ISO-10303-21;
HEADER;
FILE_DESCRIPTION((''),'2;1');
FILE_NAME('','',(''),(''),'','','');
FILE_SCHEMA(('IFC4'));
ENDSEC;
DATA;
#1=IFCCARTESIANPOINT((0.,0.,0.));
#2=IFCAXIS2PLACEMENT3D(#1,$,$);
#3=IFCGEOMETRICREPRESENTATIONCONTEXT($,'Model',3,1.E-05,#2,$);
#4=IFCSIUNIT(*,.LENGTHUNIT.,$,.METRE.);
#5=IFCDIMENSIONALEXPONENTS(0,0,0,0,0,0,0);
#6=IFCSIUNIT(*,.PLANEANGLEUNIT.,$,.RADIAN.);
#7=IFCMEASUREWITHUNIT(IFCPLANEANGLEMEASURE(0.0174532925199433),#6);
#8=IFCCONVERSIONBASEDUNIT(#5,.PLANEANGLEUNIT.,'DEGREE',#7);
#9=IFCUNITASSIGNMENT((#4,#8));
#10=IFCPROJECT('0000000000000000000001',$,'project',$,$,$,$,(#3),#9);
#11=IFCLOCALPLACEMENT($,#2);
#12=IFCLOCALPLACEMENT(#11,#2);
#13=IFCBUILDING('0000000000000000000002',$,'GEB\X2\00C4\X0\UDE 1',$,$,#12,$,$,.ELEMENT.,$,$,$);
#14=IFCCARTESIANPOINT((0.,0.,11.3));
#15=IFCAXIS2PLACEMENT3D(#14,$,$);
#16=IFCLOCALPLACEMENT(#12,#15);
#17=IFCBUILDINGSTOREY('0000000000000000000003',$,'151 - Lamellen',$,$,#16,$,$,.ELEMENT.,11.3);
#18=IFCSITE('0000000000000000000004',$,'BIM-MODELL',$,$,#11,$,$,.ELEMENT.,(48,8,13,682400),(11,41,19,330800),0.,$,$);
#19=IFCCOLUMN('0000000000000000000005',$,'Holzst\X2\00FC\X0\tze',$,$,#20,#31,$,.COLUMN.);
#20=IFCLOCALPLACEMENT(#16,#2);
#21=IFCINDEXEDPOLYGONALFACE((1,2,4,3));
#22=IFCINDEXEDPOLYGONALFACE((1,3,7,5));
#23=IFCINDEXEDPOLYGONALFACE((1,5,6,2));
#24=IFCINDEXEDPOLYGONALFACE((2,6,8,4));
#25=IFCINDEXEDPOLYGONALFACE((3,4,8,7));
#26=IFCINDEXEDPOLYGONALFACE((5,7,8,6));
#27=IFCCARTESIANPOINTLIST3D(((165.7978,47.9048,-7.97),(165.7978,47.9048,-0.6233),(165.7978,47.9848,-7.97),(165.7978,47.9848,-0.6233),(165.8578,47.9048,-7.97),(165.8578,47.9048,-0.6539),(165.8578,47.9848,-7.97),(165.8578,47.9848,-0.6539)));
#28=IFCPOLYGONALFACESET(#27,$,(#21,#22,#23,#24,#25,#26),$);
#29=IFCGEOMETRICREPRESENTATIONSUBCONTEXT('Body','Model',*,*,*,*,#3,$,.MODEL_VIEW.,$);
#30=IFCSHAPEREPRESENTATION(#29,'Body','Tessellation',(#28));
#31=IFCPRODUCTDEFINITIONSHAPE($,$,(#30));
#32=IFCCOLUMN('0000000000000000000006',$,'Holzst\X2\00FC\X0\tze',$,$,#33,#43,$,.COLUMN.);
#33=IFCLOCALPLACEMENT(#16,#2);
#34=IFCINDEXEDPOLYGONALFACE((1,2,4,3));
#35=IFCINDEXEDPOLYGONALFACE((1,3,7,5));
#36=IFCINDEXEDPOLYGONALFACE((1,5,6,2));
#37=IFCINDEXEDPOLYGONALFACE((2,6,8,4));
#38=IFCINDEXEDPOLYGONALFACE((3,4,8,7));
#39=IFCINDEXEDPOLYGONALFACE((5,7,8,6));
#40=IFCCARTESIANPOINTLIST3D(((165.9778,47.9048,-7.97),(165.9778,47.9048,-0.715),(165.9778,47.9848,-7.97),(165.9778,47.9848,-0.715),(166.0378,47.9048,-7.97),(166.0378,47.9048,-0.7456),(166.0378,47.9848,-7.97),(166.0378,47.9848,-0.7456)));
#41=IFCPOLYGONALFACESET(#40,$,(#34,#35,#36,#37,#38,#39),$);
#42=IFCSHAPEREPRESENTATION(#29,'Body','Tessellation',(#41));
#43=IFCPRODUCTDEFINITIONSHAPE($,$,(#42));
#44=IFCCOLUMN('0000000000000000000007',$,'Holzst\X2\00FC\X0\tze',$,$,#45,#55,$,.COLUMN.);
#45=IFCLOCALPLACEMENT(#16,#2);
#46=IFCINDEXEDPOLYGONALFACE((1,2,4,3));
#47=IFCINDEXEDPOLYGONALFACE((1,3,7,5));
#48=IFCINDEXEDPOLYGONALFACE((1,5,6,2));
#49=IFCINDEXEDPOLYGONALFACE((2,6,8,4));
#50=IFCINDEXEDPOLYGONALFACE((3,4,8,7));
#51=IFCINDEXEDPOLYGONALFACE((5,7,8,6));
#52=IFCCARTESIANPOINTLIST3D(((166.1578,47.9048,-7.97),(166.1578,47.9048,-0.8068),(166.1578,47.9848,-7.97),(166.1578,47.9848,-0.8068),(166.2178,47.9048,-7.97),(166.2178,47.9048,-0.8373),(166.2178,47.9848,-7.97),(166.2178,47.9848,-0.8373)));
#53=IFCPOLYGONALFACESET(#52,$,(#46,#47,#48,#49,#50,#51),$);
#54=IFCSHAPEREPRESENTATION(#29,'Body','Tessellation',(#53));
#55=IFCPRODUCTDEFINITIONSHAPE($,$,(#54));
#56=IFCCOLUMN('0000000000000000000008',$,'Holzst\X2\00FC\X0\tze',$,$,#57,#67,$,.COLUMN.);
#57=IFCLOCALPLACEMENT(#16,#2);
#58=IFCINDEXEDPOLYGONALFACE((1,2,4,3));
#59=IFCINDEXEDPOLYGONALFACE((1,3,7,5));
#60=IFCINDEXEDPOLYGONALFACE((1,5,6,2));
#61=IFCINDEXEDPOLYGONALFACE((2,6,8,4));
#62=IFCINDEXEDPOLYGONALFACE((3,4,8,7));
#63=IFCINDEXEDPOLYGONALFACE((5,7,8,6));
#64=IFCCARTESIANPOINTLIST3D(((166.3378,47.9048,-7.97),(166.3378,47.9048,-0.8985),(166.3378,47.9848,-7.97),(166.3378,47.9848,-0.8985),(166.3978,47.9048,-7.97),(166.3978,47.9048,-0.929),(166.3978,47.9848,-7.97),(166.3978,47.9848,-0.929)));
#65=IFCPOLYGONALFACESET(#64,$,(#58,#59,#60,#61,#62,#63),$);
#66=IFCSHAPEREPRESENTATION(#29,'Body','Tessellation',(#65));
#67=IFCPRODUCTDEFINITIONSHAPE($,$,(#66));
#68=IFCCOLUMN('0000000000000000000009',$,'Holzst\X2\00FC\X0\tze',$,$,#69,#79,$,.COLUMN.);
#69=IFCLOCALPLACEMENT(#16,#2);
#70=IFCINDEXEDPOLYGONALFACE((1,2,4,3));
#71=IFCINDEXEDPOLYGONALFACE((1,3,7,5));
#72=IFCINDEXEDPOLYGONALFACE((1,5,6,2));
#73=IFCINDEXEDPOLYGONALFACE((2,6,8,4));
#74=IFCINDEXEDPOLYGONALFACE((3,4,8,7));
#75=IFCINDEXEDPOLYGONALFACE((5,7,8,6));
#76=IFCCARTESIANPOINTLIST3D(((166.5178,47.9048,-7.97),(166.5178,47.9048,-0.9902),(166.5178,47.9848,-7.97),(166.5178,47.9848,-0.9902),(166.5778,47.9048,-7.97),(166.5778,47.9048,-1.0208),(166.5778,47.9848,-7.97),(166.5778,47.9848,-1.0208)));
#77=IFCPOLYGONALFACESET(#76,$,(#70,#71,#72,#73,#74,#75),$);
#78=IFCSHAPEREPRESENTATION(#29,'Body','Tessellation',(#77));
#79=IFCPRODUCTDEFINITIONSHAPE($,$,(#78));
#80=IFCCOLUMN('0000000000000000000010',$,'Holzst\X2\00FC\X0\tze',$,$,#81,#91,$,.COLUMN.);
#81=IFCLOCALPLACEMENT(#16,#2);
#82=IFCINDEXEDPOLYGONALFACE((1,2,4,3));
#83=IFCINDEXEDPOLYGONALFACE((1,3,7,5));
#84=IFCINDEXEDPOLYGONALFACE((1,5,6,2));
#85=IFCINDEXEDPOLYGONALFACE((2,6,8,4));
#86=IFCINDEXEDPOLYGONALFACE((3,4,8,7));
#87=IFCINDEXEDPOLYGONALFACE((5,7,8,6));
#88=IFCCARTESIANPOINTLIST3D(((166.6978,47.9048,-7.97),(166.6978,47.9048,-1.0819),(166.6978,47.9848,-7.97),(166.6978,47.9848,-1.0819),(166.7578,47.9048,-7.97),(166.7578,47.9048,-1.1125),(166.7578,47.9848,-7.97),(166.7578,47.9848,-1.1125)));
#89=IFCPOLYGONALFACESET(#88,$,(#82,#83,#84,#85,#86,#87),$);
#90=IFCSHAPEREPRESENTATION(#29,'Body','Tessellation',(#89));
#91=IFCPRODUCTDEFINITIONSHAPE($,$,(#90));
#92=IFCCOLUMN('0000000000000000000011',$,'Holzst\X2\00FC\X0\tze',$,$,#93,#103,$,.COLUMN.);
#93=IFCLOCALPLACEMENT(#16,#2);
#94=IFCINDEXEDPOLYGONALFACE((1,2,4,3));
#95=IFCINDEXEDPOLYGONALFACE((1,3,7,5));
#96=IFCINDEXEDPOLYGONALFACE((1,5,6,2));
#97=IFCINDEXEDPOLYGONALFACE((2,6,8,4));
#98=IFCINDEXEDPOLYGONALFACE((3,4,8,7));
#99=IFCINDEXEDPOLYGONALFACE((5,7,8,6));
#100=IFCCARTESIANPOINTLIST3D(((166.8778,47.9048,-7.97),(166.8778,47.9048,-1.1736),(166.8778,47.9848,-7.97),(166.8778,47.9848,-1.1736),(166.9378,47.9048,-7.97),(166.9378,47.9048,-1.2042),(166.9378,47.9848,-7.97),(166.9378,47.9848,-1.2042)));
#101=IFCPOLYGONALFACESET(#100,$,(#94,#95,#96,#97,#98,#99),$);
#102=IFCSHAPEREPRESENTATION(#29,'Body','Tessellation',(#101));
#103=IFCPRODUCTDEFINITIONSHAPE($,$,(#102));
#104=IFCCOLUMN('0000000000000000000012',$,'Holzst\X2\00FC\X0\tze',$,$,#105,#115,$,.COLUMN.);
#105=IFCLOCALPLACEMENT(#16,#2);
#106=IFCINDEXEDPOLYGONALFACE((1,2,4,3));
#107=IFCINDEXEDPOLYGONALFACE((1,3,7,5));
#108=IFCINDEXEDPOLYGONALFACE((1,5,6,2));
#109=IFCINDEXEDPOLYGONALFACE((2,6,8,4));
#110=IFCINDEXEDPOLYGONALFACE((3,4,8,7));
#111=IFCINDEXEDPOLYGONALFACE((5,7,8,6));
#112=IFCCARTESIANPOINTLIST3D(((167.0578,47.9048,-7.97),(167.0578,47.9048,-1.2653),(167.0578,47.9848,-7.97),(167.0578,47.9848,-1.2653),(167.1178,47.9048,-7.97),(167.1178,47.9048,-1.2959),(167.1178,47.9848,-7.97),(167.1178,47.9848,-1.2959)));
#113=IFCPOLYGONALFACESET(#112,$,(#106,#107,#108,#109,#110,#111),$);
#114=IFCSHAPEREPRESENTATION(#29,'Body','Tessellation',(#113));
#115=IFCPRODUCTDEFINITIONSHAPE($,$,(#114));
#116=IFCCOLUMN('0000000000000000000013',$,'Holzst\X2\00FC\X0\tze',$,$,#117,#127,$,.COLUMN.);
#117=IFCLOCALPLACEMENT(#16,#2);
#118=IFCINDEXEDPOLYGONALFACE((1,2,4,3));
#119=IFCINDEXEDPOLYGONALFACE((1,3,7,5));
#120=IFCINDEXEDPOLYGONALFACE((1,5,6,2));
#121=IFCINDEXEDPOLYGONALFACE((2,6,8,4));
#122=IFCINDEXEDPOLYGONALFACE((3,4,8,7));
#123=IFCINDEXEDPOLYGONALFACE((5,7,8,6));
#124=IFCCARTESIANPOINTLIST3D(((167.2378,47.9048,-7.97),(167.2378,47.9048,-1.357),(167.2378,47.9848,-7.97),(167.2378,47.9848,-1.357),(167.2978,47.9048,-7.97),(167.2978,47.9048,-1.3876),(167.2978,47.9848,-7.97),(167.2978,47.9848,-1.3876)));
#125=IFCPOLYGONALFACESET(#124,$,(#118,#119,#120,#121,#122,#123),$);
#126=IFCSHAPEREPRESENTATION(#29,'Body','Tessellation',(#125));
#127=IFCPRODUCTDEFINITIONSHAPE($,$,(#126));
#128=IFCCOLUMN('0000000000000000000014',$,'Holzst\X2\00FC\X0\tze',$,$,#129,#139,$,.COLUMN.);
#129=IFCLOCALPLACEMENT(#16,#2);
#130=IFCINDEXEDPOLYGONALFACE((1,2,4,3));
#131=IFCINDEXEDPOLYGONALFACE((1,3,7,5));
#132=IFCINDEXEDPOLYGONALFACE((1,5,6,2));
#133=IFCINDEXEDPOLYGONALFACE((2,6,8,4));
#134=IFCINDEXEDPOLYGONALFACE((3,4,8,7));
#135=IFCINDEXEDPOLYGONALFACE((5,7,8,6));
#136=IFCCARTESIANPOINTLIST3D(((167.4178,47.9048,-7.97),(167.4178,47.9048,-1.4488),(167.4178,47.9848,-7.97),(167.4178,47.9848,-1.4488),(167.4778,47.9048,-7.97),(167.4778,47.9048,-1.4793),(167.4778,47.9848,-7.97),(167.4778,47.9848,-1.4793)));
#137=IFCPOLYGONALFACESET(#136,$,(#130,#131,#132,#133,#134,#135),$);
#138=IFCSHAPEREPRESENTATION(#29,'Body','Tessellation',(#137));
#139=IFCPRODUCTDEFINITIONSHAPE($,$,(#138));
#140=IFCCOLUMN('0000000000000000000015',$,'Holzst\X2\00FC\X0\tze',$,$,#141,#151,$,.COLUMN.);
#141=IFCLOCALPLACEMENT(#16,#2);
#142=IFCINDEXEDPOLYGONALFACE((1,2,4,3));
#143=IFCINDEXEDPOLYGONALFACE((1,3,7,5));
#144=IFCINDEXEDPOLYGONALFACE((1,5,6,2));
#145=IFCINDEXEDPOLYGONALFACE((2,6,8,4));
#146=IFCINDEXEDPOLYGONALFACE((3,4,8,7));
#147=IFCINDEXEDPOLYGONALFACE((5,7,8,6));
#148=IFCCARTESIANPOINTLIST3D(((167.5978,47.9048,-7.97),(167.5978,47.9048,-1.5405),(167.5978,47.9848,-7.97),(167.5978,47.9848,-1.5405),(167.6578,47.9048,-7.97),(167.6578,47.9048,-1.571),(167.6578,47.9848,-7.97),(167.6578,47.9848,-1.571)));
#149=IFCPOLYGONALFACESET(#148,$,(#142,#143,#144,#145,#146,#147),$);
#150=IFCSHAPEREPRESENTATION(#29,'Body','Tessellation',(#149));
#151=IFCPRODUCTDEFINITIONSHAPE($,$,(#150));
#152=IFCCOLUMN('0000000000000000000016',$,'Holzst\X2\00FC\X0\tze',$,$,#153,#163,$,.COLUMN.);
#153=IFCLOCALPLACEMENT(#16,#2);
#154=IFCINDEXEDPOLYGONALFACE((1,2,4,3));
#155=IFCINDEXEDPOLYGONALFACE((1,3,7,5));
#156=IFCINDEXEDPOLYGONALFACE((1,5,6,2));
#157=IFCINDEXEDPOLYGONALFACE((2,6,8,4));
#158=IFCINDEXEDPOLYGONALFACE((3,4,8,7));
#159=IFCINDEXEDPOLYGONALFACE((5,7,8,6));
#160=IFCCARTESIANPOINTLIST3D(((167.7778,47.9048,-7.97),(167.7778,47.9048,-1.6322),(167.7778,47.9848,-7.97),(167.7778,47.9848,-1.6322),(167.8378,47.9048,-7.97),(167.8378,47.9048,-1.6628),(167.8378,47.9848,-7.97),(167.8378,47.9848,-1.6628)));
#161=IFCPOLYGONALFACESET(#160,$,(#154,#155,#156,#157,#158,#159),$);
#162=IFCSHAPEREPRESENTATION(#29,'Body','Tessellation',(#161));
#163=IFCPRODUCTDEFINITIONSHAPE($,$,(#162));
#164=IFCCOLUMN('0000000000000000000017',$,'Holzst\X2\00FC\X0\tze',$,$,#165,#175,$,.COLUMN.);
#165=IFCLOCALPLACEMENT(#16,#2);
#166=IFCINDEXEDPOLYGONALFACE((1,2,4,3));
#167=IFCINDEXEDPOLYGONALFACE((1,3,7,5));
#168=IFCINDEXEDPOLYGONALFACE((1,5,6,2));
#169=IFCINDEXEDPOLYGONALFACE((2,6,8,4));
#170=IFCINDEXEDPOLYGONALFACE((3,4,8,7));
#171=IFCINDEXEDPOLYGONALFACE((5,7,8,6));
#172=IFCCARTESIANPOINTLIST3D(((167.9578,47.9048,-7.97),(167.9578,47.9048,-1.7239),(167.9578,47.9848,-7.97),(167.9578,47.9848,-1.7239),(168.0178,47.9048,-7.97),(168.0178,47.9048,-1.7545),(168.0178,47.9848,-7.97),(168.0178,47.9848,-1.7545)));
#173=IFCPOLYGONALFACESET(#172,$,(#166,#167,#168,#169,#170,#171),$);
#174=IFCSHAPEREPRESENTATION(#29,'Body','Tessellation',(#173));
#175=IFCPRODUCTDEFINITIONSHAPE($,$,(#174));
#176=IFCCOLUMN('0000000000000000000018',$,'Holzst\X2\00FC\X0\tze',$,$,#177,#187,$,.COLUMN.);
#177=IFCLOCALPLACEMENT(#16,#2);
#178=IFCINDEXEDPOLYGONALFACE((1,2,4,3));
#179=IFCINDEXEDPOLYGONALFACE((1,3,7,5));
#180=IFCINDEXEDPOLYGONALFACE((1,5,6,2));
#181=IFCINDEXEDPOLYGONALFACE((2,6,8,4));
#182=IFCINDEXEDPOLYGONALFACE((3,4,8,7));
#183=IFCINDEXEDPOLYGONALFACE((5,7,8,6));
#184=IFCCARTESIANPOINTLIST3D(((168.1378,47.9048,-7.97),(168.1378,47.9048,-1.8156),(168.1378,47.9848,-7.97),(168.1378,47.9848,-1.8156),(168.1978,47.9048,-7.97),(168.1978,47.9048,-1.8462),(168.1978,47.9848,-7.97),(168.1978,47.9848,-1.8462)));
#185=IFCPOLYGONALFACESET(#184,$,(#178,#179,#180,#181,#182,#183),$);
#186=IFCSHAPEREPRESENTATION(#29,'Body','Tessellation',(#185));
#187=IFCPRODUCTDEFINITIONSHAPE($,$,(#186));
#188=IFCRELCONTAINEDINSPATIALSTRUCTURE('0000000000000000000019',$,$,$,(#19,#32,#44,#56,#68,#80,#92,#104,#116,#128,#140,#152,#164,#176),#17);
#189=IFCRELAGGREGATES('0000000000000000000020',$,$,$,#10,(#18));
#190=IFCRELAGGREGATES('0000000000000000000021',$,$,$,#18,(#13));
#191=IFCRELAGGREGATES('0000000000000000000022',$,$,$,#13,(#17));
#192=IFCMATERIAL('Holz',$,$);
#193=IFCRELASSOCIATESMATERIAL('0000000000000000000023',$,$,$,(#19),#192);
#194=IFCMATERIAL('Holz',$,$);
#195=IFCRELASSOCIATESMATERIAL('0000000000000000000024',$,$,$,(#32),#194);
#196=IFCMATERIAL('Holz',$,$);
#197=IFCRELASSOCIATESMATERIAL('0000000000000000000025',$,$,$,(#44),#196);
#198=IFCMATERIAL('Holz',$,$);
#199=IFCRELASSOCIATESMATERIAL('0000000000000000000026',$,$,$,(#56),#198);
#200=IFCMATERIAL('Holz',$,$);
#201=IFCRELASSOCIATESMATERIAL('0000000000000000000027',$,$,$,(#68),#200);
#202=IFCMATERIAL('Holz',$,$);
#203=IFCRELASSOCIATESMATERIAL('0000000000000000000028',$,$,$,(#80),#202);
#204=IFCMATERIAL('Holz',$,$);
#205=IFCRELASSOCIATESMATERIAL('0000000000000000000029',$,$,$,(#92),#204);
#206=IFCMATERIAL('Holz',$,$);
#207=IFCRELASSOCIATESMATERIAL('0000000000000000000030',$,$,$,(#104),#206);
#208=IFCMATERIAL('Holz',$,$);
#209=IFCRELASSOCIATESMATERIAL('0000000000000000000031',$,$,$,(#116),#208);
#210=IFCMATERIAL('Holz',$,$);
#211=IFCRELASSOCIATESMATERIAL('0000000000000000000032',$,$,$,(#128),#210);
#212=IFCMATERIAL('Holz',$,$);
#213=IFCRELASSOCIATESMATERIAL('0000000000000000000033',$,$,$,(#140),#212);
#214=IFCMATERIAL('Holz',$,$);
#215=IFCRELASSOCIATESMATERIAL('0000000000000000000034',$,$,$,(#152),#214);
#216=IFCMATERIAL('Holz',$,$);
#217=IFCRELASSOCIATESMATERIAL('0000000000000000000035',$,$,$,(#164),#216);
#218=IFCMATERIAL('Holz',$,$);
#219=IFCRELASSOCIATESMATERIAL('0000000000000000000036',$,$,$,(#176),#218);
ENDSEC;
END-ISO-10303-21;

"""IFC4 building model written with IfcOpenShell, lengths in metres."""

from ifc_helpers import new_model, entity, si_unit, converted_unit, frame, frame_2d, origin, origin_with_axes, place, context, subcontext, project, spatial, rectangle, extrude, clip, halfspace, material, element, save


model = new_model("IFC4")

# Units and contexts
model_context = context("Model", 3, precision=1e-05, world=origin())
body_context = subcontext(model_context, "Body", "Model", "MODEL_VIEW")
ifc_project = project(units=[si_unit("LENGTHUNIT", "METRE"), converted_unit("PLANEANGLEUNIT", "DEGREE", entity("IfcPlaneAngleMeasure", 0.0174532925199433), si_unit("PLANEANGLEUNIT", "RADIAN"), dimensions=[0, 0, 0, 0, 0, 0, 0])], contexts=[model_context])

# Site, building, storey
site_placement = place(None, origin())
site = spatial("IfcSite", under=ifc_project, at=site_placement, Name="BIM-MODELL", CompositionType="ELEMENT", RefLatitude=(48, 8, 13, 682400), RefLongitude=(11, 41, 19, 330800), RefElevation=0.0)
building_placement = place(site_placement, origin())
building = spatial("IfcBuilding", under=site, at=building_placement, Name="GEBÄUDE 1", CompositionType="ELEMENT")
storey_placement = place(building_placement, frame((0.0, 0.0, 11.3)))
storey = spatial("IfcBuildingStorey", under=building, at=storey_placement, Name="151 - Lamellen", CompositionType="ELEMENT", Elevation=11.3)

# Columns
ifc_material_1 = material(Name="Holz")
column_1_placement = place(storey_placement, frame((165.7978, 47.9048, -7.97)))
element("IfcColumn", 1, at=column_1_placement, inside=storey, material=ifc_material_1, Name="Holzstütze", PredefinedType="COLUMN", context=body_context, shape_type="Clipping", body=[
    clip(extrude(rectangle(XDim=0.06, YDim=0.08, at=frame_2d((0.03, 0.04), x_axis=(1.0, 0.0))), origin_with_axes(), (0.0, 0.0, 1.0), 7.3467), halfspace(frame((0.03, 0.04, 7.3314), z_axis=(-0.45399, 0.0, -0.891007), x_axis=(0.0, 1.0, 0.0)), True)),
])
ifc_material_2 = material(Name="Holz")
column_2_placement = place(storey_placement, frame((165.9778, 47.9048, -7.97)))
element("IfcColumn", 2, at=column_2_placement, inside=storey, material=ifc_material_2, Name="Holzstütze", PredefinedType="COLUMN", context=body_context, shape_type="Clipping", body=[
    clip(extrude(rectangle(XDim=0.06, YDim=0.08, at=frame_2d((0.03, 0.04), x_axis=(1.0, 0.0))), origin_with_axes(), (0.0, 0.0, 1.0), 7.255), halfspace(frame((0.03, 0.04, 7.2397), z_axis=(-0.45399, 0.0, -0.891007), x_axis=(0.0, 1.0, 0.0)), True)),
])
ifc_material_3 = material(Name="Holz")
column_3_placement = place(storey_placement, frame((166.1578, 47.9048, -7.97)))
element("IfcColumn", 3, at=column_3_placement, inside=storey, material=ifc_material_3, Name="Holzstütze", PredefinedType="COLUMN", context=body_context, shape_type="Clipping", body=[
    clip(extrude(rectangle(XDim=0.06, YDim=0.08, at=frame_2d((0.03, 0.04), x_axis=(1.0, 0.0))), origin_with_axes(), (0.0, 0.0, 1.0), 7.1632), halfspace(frame((0.03, 0.04, 7.148), z_axis=(-0.45399, 0.0, -0.891007), x_axis=(0.0, 1.0, 0.0)), True)),
])
ifc_material_4 = material(Name="Holz")
column_4_placement = place(storey_placement, frame((166.3378, 47.9048, -7.97)))
element("IfcColumn", 4, at=column_4_placement, inside=storey, material=ifc_material_4, Name="Holzstütze", PredefinedType="COLUMN", context=body_context, shape_type="Clipping", body=[
    clip(extrude(rectangle(XDim=0.06, YDim=0.08, at=frame_2d((0.03, 0.04), x_axis=(1.0, 0.0))), origin_with_axes(), (0.0, 0.0, 1.0), 7.0715), halfspace(frame((0.03, 0.04, 7.0562), z_axis=(-0.45399, 0.0, -0.891007), x_axis=(0.0, 1.0, 0.0)), True)),
])
ifc_material_5 = material(Name="Holz")
column_5_placement = place(storey_placement, frame((166.5178, 47.9048, -7.97)))
element("IfcColumn", 5, at=column_5_placement, inside=storey, material=ifc_material_5, Name="Holzstütze", PredefinedType="COLUMN", context=body_context, shape_type="Clipping", body=[
    clip(extrude(rectangle(XDim=0.06, YDim=0.08, at=frame_2d((0.03, 0.04), x_axis=(1.0, 0.0))), origin_with_axes(), (0.0, 0.0, 1.0), 6.9798), halfspace(frame((0.03, 0.04, 6.9645), z_axis=(-0.45399, 0.0, -0.891007), x_axis=(0.0, 1.0, 0.0)), True)),
])
ifc_material_6 = material(Name="Holz")
column_6_placement = place(storey_placement, frame((166.6978, 47.9048, -7.97)))
element("IfcColumn", 6, at=column_6_placement, inside=storey, material=ifc_material_6, Name="Holzstütze", PredefinedType="COLUMN", context=body_context, shape_type="Clipping", body=[
    clip(extrude(rectangle(XDim=0.06, YDim=0.08, at=frame_2d((0.03, 0.04), x_axis=(1.0, 0.0))), origin_with_axes(), (0.0, 0.0, 1.0), 6.8881), halfspace(frame((0.03, 0.04, 6.8728), z_axis=(-0.45399, 0.0, -0.891007), x_axis=(0.0, 1.0, 0.0)), True)),
])
ifc_material_7 = material(Name="Holz")
column_7_placement = place(storey_placement, frame((166.8778, 47.9048, -7.97)))
element("IfcColumn", 7, at=column_7_placement, inside=storey, material=ifc_material_7, Name="Holzstütze", PredefinedType="COLUMN", context=body_context, shape_type="Clipping", body=[
    clip(extrude(rectangle(XDim=0.06, YDim=0.08, at=frame_2d((0.03, 0.04), x_axis=(1.0, 0.0))), origin_with_axes(), (0.0, 0.0, 1.0), 6.7964), halfspace(frame((0.03, 0.04, 6.7811), z_axis=(-0.45399, 0.0, -0.891007), x_axis=(0.0, 1.0, 0.0)), True)),
])
ifc_material_8 = material(Name="Holz")
column_8_placement = place(storey_placement, frame((167.0578, 47.9048, -7.97)))
element("IfcColumn", 8, at=column_8_placement, inside=storey, material=ifc_material_8, Name="Holzstütze", PredefinedType="COLUMN", context=body_context, shape_type="Clipping", body=[
    clip(extrude(rectangle(XDim=0.06, YDim=0.08, at=frame_2d((0.03, 0.04), x_axis=(1.0, 0.0))), origin_with_axes(), (0.0, 0.0, 1.0), 6.7047), halfspace(frame((0.03, 0.04, 6.6894), z_axis=(-0.45399, 0.0, -0.891007), x_axis=(0.0, 1.0, 0.0)), True)),
])
ifc_material_9 = material(Name="Holz")
column_9_placement = place(storey_placement, frame((167.2378, 47.9048, -7.97)))
element("IfcColumn", 9, at=column_9_placement, inside=storey, material=ifc_material_9, Name="Holzstütze", PredefinedType="COLUMN", context=body_context, shape_type="Clipping", body=[
    clip(extrude(rectangle(XDim=0.06, YDim=0.08, at=frame_2d((0.03, 0.04), x_axis=(1.0, 0.0))), origin_with_axes(), (0.0, 0.0, 1.0), 6.613), halfspace(frame((0.03, 0.04, 6.5977), z_axis=(-0.45399, 0.0, -0.891007), x_axis=(0.0, 1.0, 0.0)), True)),
])
ifc_material_10 = material(Name="Holz")
column_10_placement = place(storey_placement, frame((167.4178, 47.9048, -7.97)))
element("IfcColumn", 10, at=column_10_placement, inside=storey, material=ifc_material_10, Name="Holzstütze", PredefinedType="COLUMN", context=body_context, shape_type="Clipping", body=[
    clip(extrude(rectangle(XDim=0.06, YDim=0.08, at=frame_2d((0.03, 0.04), x_axis=(1.0, 0.0))), origin_with_axes(), (0.0, 0.0, 1.0), 6.5212), halfspace(frame((0.03, 0.04, 6.506), z_axis=(-0.45399, 0.0, -0.891007), x_axis=(0.0, 1.0, 0.0)), True)),
])
ifc_material_11 = material(Name="Holz")
column_11_placement = place(storey_placement, frame((167.5978, 47.9048, -7.97)))
element("IfcColumn", 11, at=column_11_placement, inside=storey, material=ifc_material_11, Name="Holzstütze", PredefinedType="COLUMN", context=body_context, shape_type="Clipping", body=[
    clip(extrude(rectangle(XDim=0.06, YDim=0.08, at=frame_2d((0.03, 0.04), x_axis=(1.0, 0.0))), origin_with_axes(), (0.0, 0.0, 1.0), 6.4295), halfspace(frame((0.03, 0.04, 6.4142), z_axis=(-0.45399, 0.0, -0.891007), x_axis=(0.0, 1.0, 0.0)), True)),
])
ifc_material_12 = material(Name="Holz")
column_12_placement = place(storey_placement, frame((167.7778, 47.9048, -7.97)))
element("IfcColumn", 12, at=column_12_placement, inside=storey, material=ifc_material_12, Name="Holzstütze", PredefinedType="COLUMN", context=body_context, shape_type="Clipping", body=[
    clip(extrude(rectangle(XDim=0.06, YDim=0.08, at=frame_2d((0.03, 0.04), x_axis=(1.0, 0.0))), origin_with_axes(), (0.0, 0.0, 1.0), 6.3378), halfspace(frame((0.03, 0.04, 6.3225), z_axis=(-0.45399, 0.0, -0.891007), x_axis=(0.0, 1.0, 0.0)), True)),
])
ifc_material_13 = material(Name="Holz")
column_13_placement = place(storey_placement, frame((167.9578, 47.9048, -7.97)))
element("IfcColumn", 13, at=column_13_placement, inside=storey, material=ifc_material_13, Name="Holzstütze", PredefinedType="COLUMN", context=body_context, shape_type="Clipping", body=[
    clip(extrude(rectangle(XDim=0.06, YDim=0.08, at=frame_2d((0.03, 0.04), x_axis=(1.0, 0.0))), origin_with_axes(), (0.0, 0.0, 1.0), 6.2461), halfspace(frame((0.03, 0.04, 6.2308), z_axis=(-0.45399, 0.0, -0.891007), x_axis=(0.0, 1.0, 0.0)), True)),
])
ifc_material_14 = material(Name="Holz")
column_14_placement = place(storey_placement, frame((168.1378, 47.9048, -7.97)))
element("IfcColumn", 14, at=column_14_placement, inside=storey, material=ifc_material_14, Name="Holzstütze", PredefinedType="COLUMN", context=body_context, shape_type="Clipping", body=[
    clip(extrude(rectangle(XDim=0.06, YDim=0.08, at=frame_2d((0.03, 0.04), x_axis=(1.0, 0.0))), origin_with_axes(), (0.0, 0.0, 1.0), 6.1544), halfspace(frame((0.03, 0.04, 6.1391), z_axis=(-0.45399, 0.0, -0.891007), x_axis=(0.0, 1.0, 0.0)), True)),
])

save(model, "model.ifc")
